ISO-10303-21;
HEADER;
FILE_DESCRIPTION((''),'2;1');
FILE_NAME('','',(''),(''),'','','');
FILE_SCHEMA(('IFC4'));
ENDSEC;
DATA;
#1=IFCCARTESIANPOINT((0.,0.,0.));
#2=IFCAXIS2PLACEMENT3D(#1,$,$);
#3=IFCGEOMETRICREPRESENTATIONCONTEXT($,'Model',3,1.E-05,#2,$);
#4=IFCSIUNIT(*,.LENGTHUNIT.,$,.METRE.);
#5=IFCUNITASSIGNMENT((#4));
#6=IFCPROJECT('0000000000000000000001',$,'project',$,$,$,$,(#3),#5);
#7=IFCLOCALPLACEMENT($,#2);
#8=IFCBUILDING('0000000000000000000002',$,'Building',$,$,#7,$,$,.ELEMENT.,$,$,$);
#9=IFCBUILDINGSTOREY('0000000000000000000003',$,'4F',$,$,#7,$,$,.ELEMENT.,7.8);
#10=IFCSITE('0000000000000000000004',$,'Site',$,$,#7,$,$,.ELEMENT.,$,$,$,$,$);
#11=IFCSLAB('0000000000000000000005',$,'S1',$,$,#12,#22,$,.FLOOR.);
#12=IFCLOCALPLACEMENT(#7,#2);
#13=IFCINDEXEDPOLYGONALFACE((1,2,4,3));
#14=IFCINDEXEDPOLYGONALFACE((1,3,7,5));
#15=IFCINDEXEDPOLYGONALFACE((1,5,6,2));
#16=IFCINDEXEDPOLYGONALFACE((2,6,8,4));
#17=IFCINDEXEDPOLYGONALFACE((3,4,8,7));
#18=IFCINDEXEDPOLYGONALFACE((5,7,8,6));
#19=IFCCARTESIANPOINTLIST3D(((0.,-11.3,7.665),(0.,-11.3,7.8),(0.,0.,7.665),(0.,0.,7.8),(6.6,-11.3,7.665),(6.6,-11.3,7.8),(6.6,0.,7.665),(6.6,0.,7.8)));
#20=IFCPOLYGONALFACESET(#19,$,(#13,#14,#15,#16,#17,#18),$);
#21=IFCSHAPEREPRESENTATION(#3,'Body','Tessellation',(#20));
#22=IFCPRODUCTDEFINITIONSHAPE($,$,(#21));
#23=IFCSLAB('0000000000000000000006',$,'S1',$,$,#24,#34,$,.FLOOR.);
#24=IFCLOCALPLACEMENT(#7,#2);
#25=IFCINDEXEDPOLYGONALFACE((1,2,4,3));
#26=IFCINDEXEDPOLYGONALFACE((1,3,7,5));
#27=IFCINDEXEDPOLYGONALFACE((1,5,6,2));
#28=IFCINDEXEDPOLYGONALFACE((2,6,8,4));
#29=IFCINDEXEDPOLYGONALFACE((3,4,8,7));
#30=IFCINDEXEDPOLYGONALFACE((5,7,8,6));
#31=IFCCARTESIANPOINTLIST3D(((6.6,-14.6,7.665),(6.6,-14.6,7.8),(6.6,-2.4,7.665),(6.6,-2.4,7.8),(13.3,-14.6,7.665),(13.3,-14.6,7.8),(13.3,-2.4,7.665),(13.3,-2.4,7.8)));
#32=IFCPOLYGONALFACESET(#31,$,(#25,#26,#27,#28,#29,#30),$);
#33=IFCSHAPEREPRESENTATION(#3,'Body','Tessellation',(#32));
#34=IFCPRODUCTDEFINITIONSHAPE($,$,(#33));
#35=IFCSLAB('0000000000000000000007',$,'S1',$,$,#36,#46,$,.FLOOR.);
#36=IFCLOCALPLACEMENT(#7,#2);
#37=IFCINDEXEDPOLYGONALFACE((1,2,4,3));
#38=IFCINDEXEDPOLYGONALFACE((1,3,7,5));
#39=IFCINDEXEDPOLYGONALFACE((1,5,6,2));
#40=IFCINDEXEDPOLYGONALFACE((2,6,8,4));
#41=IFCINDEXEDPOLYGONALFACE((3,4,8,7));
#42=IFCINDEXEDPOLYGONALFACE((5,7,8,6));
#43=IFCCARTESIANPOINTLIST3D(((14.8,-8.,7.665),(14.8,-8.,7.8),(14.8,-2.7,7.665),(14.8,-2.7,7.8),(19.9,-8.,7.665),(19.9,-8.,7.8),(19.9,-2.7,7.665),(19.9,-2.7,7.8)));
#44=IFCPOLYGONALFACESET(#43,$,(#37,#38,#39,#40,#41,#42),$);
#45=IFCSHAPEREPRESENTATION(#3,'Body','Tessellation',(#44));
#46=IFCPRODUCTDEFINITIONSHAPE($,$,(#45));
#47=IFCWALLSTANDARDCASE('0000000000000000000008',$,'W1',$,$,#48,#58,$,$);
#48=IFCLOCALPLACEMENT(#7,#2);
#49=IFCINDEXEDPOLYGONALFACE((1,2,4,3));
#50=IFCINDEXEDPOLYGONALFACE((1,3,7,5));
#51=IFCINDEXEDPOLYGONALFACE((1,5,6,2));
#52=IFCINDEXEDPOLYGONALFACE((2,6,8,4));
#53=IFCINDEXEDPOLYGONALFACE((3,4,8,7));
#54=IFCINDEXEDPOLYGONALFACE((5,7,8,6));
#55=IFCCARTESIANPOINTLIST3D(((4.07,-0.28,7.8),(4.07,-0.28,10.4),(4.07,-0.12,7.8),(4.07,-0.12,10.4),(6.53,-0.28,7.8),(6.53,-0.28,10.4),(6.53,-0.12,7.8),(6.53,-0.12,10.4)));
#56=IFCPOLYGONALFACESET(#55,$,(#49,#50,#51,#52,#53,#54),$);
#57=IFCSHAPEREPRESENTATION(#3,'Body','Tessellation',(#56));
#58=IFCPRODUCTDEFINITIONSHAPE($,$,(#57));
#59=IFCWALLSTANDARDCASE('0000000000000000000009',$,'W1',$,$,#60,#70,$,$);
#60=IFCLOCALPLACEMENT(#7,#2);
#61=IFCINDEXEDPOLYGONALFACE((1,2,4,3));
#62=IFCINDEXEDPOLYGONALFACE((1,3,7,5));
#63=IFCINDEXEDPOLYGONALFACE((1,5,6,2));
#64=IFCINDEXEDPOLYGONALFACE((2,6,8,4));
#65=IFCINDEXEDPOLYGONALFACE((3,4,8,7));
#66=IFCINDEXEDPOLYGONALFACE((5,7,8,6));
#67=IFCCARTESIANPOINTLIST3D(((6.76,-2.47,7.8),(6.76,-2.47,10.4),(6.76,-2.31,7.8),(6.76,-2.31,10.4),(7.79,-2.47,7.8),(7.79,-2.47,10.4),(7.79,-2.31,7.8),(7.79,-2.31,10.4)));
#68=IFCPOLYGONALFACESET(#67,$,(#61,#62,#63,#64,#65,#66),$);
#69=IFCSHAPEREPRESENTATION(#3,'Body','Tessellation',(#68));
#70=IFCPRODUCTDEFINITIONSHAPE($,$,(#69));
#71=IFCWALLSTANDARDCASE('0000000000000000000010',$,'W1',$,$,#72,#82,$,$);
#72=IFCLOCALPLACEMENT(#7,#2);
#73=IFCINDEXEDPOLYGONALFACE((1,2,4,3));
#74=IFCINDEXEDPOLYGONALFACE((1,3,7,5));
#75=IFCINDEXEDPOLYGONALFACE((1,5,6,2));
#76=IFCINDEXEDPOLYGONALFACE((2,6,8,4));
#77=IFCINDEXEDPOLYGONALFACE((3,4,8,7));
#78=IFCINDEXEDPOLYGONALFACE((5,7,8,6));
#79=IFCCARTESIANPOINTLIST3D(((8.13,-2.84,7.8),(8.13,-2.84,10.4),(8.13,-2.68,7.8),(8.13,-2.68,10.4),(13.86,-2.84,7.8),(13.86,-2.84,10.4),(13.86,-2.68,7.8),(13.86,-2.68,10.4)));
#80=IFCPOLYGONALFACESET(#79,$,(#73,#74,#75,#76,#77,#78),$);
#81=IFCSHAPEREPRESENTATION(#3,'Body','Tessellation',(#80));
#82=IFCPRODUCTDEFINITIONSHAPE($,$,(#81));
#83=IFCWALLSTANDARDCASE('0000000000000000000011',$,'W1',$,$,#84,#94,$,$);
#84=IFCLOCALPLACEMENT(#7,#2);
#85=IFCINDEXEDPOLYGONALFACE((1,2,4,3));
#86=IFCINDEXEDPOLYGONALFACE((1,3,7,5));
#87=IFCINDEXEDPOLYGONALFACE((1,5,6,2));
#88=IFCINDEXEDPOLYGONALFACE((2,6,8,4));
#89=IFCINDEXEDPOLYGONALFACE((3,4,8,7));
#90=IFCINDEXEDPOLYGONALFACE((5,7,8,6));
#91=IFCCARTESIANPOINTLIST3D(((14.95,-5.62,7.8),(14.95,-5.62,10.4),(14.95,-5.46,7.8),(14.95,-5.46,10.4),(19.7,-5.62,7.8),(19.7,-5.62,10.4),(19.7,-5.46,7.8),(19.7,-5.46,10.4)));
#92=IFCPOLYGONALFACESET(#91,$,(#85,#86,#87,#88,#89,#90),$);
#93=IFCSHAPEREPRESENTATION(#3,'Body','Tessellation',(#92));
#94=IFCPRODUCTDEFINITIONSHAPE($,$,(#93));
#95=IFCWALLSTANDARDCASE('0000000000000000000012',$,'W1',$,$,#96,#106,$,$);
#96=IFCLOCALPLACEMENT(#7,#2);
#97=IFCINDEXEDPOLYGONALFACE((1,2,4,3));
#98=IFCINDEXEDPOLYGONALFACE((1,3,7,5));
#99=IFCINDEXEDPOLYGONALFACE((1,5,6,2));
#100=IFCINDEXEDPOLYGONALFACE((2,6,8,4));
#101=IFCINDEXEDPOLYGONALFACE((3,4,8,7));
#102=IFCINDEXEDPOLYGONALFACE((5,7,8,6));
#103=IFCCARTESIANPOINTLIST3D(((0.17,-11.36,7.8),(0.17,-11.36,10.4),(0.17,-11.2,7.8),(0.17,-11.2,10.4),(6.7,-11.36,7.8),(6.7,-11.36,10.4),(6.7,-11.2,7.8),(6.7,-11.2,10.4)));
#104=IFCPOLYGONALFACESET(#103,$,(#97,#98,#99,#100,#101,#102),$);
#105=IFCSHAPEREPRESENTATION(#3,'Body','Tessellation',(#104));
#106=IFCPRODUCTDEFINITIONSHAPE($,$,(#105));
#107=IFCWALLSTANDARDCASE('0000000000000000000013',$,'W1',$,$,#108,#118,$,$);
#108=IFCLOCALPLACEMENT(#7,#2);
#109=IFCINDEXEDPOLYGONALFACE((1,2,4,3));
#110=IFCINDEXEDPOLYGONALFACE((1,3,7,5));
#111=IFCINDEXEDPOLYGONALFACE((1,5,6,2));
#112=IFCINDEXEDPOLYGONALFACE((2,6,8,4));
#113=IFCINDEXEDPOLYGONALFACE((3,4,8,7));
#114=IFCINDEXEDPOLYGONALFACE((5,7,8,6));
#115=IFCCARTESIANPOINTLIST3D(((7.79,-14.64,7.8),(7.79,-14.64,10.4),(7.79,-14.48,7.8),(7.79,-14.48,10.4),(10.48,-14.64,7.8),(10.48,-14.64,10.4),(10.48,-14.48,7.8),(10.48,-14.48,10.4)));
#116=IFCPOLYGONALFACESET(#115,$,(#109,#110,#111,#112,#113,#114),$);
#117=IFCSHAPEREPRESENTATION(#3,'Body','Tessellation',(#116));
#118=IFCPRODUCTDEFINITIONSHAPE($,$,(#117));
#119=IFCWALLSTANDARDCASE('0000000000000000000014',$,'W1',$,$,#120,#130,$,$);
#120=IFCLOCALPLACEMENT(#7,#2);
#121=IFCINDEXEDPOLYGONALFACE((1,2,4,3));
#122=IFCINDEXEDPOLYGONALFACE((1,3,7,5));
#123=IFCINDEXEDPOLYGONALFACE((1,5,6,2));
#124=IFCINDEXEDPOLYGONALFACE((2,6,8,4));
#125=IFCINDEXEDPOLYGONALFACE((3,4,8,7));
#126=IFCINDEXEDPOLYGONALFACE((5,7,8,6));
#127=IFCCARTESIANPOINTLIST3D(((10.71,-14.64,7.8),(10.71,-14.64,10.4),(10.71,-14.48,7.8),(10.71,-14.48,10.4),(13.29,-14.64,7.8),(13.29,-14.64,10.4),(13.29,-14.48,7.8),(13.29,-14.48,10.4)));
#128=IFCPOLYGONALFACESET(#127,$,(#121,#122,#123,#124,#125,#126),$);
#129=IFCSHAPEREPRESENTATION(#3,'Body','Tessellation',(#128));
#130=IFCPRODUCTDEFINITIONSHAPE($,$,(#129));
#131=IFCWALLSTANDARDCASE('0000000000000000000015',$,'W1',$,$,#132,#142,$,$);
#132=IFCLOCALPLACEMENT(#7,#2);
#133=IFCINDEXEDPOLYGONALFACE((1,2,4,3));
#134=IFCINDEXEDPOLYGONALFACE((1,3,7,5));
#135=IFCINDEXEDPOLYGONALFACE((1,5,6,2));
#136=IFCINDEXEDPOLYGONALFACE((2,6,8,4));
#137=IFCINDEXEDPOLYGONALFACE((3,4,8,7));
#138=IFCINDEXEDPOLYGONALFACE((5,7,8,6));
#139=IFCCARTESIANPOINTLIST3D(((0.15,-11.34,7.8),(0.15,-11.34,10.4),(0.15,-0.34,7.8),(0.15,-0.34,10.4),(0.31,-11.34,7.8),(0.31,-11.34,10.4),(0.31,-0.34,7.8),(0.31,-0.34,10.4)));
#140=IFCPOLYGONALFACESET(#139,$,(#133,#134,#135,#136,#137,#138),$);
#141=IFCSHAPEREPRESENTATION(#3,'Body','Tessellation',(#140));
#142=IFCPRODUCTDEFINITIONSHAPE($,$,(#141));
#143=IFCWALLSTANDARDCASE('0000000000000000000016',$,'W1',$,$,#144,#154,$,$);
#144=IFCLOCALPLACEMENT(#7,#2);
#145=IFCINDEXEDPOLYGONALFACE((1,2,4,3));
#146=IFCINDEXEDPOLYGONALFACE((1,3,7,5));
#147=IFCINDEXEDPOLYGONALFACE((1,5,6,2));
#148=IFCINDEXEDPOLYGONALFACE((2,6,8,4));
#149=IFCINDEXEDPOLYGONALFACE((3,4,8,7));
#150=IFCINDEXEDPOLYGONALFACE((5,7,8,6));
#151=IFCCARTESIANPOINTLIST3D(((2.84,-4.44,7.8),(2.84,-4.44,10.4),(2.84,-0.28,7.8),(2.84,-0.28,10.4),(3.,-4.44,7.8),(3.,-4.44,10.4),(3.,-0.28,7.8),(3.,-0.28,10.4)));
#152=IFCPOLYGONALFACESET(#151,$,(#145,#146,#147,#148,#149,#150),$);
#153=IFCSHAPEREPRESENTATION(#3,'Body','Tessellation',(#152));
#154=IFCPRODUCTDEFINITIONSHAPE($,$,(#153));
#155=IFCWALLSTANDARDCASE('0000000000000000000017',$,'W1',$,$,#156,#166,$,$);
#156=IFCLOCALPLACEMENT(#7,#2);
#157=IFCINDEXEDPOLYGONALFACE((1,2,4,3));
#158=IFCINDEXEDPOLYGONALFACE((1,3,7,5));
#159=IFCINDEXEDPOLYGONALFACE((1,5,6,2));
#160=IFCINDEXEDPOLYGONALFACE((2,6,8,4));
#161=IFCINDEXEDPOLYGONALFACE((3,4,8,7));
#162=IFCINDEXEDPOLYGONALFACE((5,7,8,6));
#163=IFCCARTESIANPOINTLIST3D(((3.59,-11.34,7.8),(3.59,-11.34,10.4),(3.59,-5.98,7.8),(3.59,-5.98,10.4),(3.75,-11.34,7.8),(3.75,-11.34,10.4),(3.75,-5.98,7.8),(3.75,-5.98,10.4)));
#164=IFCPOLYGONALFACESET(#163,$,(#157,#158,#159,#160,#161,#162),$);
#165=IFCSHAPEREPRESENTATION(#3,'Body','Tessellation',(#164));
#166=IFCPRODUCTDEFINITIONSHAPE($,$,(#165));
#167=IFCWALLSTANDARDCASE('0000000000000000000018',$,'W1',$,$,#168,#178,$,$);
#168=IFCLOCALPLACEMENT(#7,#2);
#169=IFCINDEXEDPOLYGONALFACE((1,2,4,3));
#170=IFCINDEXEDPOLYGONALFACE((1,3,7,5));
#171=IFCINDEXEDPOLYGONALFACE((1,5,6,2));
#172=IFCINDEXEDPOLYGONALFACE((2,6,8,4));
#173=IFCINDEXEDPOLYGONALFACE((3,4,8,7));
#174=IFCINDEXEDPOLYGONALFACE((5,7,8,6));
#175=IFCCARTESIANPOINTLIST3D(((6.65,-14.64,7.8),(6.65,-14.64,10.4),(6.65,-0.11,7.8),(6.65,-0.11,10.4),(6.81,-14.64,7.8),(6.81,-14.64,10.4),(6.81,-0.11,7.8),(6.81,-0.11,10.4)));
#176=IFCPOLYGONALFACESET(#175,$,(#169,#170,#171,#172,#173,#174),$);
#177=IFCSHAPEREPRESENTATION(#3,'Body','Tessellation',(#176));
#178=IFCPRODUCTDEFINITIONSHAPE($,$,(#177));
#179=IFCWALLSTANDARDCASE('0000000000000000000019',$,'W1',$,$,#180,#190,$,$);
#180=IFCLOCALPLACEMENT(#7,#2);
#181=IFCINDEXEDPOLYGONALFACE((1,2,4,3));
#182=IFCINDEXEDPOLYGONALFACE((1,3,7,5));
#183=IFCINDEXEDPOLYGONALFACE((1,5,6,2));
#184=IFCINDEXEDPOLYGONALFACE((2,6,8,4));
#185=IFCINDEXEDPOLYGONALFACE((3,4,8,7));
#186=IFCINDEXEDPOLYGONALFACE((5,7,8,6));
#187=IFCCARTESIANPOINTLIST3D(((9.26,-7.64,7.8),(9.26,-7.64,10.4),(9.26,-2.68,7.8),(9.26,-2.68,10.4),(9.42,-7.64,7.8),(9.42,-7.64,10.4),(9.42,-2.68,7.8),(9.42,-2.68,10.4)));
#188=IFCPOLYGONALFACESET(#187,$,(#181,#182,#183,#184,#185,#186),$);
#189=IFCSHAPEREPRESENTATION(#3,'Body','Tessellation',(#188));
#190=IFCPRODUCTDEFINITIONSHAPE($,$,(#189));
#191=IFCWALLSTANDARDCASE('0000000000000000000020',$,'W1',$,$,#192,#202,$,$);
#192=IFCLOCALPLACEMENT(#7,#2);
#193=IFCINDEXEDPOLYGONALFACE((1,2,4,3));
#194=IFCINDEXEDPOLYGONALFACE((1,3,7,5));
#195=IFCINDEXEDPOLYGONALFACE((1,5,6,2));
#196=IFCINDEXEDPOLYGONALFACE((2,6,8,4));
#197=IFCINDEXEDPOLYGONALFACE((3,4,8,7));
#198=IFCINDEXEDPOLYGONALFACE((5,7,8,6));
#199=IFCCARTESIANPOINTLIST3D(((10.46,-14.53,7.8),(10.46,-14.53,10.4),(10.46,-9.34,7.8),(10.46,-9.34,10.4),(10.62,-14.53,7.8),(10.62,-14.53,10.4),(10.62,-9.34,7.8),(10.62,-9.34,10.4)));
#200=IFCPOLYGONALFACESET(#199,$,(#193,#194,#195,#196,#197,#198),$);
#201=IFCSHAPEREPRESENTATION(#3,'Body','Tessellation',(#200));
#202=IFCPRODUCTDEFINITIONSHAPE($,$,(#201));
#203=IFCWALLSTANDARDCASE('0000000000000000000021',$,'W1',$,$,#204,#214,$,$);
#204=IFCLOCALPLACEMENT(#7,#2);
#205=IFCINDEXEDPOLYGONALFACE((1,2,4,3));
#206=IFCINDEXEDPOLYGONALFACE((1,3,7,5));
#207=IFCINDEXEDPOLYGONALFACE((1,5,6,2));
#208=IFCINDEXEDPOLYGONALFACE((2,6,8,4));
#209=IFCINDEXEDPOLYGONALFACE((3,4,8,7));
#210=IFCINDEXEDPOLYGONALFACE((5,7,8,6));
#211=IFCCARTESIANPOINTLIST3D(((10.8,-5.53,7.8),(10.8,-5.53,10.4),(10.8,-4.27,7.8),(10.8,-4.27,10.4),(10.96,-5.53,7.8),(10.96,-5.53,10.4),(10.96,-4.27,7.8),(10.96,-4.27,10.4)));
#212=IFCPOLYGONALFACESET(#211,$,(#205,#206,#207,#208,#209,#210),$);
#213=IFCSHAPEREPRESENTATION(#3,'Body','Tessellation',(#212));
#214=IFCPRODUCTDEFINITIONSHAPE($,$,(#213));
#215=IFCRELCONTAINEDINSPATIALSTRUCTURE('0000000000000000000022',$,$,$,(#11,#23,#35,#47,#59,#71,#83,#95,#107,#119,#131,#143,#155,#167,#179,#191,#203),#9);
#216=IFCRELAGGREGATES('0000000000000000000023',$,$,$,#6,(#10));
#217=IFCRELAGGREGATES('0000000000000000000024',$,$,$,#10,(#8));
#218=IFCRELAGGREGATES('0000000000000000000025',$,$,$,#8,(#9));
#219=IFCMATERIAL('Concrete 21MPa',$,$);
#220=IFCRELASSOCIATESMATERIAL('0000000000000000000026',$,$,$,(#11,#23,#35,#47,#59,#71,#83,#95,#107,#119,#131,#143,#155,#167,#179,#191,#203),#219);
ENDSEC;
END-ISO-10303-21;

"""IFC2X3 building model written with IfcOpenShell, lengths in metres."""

from ifc_helpers import new_model, si_unit, frame, origin, origin_2d, place, context, project, spatial, rectangle, extrude, material, element, save


model = new_model("IFC2X3")

# Units and contexts
model_context = context("Model", 3, precision=1e-05, world=origin())
ifc_project = project(units=[si_unit("LENGTHUNIT", "METRE")], contexts=[model_context])

# Site, building, storey
placement = place(None, origin())
site = spatial("IfcSite", under=ifc_project, at=placement, Name="Site", CompositionType="ELEMENT")
building = spatial("IfcBuilding", under=site, at=placement, Name="Building", CompositionType="ELEMENT")
storey = spatial("IfcBuildingStorey", under=building, at=placement, Name="4F", CompositionType="ELEMENT", Elevation=7.8)

# Slabs
ifc_material_1 = material(Name="Concrete 21MPa")
slab_1_placement = place(None, frame((3.3, -5.65, 7.665)))
element("IfcSlab", 1, at=slab_1_placement, inside=storey, material=ifc_material_1, Name="S1", PredefinedType="FLOOR", context=model_context, shape_type="SweptSolid", body=[
    extrude(rectangle(XDim=6.6, YDim=11.3, at=origin_2d()), origin(), (0.0, 0.0, 1.0), 0.135),
])
slab_2_placement = place(None, frame((9.95, -8.5, 7.665)))
element("IfcSlab", 2, at=slab_2_placement, inside=storey, material=ifc_material_1, Name="S1", PredefinedType="FLOOR", context=model_context, shape_type="SweptSolid", body=[
    extrude(rectangle(XDim=6.7, YDim=12.2, at=origin_2d()), origin(), (0.0, 0.0, 1.0), 0.135),
])
slab_3_placement = place(None, frame((17.35, -5.35, 7.665)))
element("IfcSlab", 3, at=slab_3_placement, inside=storey, material=ifc_material_1, Name="S1", PredefinedType="FLOOR", context=model_context, shape_type="SweptSolid", body=[
    extrude(rectangle(XDim=5.1, YDim=5.3, at=origin_2d()), origin(), (0.0, 0.0, 1.0), 0.135),
])

# Walls
wall_1_placement = place(None, frame((5.3, -0.2, 7.8)))
element("IfcWallStandardCase", 4, at=wall_1_placement, inside=storey, material=ifc_material_1, Name="W1", context=model_context, shape_type="SweptSolid", body=[
    extrude(rectangle(XDim=2.46, YDim=0.16, at=origin_2d()), origin(), (0.0, 0.0, 1.0), 2.6),
])
wall_2_placement = place(None, frame((7.275, -2.39, 7.8)))
element("IfcWallStandardCase", 5, at=wall_2_placement, inside=storey, material=ifc_material_1, Name="W1", context=model_context, shape_type="SweptSolid", body=[
    extrude(rectangle(XDim=1.03, YDim=0.16, at=origin_2d()), origin(), (0.0, 0.0, 1.0), 2.6),
])
wall_3_placement = place(None, frame((10.995, -2.76, 7.8)))
element("IfcWallStandardCase", 6, at=wall_3_placement, inside=storey, material=ifc_material_1, Name="W1", context=model_context, shape_type="SweptSolid", body=[
    extrude(rectangle(XDim=5.73, YDim=0.16, at=origin_2d()), origin(), (0.0, 0.0, 1.0), 2.6),
])
wall_4_placement = place(None, frame((17.325, -5.54, 7.8)))
element("IfcWallStandardCase", 7, at=wall_4_placement, inside=storey, material=ifc_material_1, Name="W1", context=model_context, shape_type="SweptSolid", body=[
    extrude(rectangle(XDim=4.75, YDim=0.16, at=origin_2d()), origin(), (0.0, 0.0, 1.0), 2.6),
])
wall_5_placement = place(None, frame((3.435, -11.28, 7.8)))
element("IfcWallStandardCase", 8, at=wall_5_placement, inside=storey, material=ifc_material_1, Name="W1", context=model_context, shape_type="SweptSolid", body=[
    extrude(rectangle(XDim=6.53, YDim=0.16, at=origin_2d()), origin(), (0.0, 0.0, 1.0), 2.6),
])
wall_6_placement = place(None, frame((9.135, -14.56, 7.8)))
element("IfcWallStandardCase", 9, at=wall_6_placement, inside=storey, material=ifc_material_1, Name="W1", context=model_context, shape_type="SweptSolid", body=[
    extrude(rectangle(XDim=2.69, YDim=0.16, at=origin_2d()), origin(), (0.0, 0.0, 1.0), 2.6),
])
wall_7_placement = place(None, frame((12.0, -14.56, 7.8)))
element("IfcWallStandardCase", 10, at=wall_7_placement, inside=storey, material=ifc_material_1, Name="W1", context=model_context, shape_type="SweptSolid", body=[
    extrude(rectangle(XDim=2.58, YDim=0.16, at=origin_2d()), origin(), (0.0, 0.0, 1.0), 2.6),
])
wall_8_placement = place(None, frame((0.23, -5.84, 7.8)))
element("IfcWallStandardCase", 11, at=wall_8_placement, inside=storey, material=ifc_material_1, Name="W1", context=model_context, shape_type="SweptSolid", body=[
    extrude(rectangle(XDim=0.16, YDim=11.0, at=origin_2d()), origin(), (0.0, 0.0, 1.0), 2.6),
])
wall_9_placement = place(None, frame((2.92, -2.36, 7.8)))
element("IfcWallStandardCase", 12, at=wall_9_placement, inside=storey, material=ifc_material_1, Name="W1", context=model_context, shape_type="SweptSolid", body=[
    extrude(rectangle(XDim=0.16, YDim=4.16, at=origin_2d()), origin(), (0.0, 0.0, 1.0), 2.6),
])
wall_10_placement = place(None, frame((3.67, -8.66, 7.8)))
element("IfcWallStandardCase", 13, at=wall_10_placement, inside=storey, material=ifc_material_1, Name="W1", context=model_context, shape_type="SweptSolid", body=[
    extrude(rectangle(XDim=0.16, YDim=5.36, at=origin_2d()), origin(), (0.0, 0.0, 1.0), 2.6),
])
wall_11_placement = place(None, frame((6.73, -7.375, 7.8)))
element("IfcWallStandardCase", 14, at=wall_11_placement, inside=storey, material=ifc_material_1, Name="W1", context=model_context, shape_type="SweptSolid", body=[
    extrude(rectangle(XDim=0.16, YDim=14.53, at=origin_2d()), origin(), (0.0, 0.0, 1.0), 2.6),
])
wall_12_placement = place(None, frame((9.34, -5.16, 7.8)))
element("IfcWallStandardCase", 15, at=wall_12_placement, inside=storey, material=ifc_material_1, Name="W1", context=model_context, shape_type="SweptSolid", body=[
    extrude(rectangle(XDim=0.16, YDim=4.96, at=origin_2d()), origin(), (0.0, 0.0, 1.0), 2.6),
])
wall_13_placement = place(None, frame((10.54, -11.935, 7.8)))
element("IfcWallStandardCase", 16, at=wall_13_placement, inside=storey, material=ifc_material_1, Name="W1", context=model_context, shape_type="SweptSolid", body=[
    extrude(rectangle(XDim=0.16, YDim=5.19, at=origin_2d()), origin(), (0.0, 0.0, 1.0), 2.6),
])
wall_14_placement = place(None, frame((10.88, -4.9, 7.8)))
element("IfcWallStandardCase", 17, at=wall_14_placement, inside=storey, material=ifc_material_1, Name="W1", context=model_context, shape_type="SweptSolid", body=[
    extrude(rectangle(XDim=0.16, YDim=1.26, at=origin_2d()), origin(), (0.0, 0.0, 1.0), 2.6),
])

save(model, "model.ifc")
